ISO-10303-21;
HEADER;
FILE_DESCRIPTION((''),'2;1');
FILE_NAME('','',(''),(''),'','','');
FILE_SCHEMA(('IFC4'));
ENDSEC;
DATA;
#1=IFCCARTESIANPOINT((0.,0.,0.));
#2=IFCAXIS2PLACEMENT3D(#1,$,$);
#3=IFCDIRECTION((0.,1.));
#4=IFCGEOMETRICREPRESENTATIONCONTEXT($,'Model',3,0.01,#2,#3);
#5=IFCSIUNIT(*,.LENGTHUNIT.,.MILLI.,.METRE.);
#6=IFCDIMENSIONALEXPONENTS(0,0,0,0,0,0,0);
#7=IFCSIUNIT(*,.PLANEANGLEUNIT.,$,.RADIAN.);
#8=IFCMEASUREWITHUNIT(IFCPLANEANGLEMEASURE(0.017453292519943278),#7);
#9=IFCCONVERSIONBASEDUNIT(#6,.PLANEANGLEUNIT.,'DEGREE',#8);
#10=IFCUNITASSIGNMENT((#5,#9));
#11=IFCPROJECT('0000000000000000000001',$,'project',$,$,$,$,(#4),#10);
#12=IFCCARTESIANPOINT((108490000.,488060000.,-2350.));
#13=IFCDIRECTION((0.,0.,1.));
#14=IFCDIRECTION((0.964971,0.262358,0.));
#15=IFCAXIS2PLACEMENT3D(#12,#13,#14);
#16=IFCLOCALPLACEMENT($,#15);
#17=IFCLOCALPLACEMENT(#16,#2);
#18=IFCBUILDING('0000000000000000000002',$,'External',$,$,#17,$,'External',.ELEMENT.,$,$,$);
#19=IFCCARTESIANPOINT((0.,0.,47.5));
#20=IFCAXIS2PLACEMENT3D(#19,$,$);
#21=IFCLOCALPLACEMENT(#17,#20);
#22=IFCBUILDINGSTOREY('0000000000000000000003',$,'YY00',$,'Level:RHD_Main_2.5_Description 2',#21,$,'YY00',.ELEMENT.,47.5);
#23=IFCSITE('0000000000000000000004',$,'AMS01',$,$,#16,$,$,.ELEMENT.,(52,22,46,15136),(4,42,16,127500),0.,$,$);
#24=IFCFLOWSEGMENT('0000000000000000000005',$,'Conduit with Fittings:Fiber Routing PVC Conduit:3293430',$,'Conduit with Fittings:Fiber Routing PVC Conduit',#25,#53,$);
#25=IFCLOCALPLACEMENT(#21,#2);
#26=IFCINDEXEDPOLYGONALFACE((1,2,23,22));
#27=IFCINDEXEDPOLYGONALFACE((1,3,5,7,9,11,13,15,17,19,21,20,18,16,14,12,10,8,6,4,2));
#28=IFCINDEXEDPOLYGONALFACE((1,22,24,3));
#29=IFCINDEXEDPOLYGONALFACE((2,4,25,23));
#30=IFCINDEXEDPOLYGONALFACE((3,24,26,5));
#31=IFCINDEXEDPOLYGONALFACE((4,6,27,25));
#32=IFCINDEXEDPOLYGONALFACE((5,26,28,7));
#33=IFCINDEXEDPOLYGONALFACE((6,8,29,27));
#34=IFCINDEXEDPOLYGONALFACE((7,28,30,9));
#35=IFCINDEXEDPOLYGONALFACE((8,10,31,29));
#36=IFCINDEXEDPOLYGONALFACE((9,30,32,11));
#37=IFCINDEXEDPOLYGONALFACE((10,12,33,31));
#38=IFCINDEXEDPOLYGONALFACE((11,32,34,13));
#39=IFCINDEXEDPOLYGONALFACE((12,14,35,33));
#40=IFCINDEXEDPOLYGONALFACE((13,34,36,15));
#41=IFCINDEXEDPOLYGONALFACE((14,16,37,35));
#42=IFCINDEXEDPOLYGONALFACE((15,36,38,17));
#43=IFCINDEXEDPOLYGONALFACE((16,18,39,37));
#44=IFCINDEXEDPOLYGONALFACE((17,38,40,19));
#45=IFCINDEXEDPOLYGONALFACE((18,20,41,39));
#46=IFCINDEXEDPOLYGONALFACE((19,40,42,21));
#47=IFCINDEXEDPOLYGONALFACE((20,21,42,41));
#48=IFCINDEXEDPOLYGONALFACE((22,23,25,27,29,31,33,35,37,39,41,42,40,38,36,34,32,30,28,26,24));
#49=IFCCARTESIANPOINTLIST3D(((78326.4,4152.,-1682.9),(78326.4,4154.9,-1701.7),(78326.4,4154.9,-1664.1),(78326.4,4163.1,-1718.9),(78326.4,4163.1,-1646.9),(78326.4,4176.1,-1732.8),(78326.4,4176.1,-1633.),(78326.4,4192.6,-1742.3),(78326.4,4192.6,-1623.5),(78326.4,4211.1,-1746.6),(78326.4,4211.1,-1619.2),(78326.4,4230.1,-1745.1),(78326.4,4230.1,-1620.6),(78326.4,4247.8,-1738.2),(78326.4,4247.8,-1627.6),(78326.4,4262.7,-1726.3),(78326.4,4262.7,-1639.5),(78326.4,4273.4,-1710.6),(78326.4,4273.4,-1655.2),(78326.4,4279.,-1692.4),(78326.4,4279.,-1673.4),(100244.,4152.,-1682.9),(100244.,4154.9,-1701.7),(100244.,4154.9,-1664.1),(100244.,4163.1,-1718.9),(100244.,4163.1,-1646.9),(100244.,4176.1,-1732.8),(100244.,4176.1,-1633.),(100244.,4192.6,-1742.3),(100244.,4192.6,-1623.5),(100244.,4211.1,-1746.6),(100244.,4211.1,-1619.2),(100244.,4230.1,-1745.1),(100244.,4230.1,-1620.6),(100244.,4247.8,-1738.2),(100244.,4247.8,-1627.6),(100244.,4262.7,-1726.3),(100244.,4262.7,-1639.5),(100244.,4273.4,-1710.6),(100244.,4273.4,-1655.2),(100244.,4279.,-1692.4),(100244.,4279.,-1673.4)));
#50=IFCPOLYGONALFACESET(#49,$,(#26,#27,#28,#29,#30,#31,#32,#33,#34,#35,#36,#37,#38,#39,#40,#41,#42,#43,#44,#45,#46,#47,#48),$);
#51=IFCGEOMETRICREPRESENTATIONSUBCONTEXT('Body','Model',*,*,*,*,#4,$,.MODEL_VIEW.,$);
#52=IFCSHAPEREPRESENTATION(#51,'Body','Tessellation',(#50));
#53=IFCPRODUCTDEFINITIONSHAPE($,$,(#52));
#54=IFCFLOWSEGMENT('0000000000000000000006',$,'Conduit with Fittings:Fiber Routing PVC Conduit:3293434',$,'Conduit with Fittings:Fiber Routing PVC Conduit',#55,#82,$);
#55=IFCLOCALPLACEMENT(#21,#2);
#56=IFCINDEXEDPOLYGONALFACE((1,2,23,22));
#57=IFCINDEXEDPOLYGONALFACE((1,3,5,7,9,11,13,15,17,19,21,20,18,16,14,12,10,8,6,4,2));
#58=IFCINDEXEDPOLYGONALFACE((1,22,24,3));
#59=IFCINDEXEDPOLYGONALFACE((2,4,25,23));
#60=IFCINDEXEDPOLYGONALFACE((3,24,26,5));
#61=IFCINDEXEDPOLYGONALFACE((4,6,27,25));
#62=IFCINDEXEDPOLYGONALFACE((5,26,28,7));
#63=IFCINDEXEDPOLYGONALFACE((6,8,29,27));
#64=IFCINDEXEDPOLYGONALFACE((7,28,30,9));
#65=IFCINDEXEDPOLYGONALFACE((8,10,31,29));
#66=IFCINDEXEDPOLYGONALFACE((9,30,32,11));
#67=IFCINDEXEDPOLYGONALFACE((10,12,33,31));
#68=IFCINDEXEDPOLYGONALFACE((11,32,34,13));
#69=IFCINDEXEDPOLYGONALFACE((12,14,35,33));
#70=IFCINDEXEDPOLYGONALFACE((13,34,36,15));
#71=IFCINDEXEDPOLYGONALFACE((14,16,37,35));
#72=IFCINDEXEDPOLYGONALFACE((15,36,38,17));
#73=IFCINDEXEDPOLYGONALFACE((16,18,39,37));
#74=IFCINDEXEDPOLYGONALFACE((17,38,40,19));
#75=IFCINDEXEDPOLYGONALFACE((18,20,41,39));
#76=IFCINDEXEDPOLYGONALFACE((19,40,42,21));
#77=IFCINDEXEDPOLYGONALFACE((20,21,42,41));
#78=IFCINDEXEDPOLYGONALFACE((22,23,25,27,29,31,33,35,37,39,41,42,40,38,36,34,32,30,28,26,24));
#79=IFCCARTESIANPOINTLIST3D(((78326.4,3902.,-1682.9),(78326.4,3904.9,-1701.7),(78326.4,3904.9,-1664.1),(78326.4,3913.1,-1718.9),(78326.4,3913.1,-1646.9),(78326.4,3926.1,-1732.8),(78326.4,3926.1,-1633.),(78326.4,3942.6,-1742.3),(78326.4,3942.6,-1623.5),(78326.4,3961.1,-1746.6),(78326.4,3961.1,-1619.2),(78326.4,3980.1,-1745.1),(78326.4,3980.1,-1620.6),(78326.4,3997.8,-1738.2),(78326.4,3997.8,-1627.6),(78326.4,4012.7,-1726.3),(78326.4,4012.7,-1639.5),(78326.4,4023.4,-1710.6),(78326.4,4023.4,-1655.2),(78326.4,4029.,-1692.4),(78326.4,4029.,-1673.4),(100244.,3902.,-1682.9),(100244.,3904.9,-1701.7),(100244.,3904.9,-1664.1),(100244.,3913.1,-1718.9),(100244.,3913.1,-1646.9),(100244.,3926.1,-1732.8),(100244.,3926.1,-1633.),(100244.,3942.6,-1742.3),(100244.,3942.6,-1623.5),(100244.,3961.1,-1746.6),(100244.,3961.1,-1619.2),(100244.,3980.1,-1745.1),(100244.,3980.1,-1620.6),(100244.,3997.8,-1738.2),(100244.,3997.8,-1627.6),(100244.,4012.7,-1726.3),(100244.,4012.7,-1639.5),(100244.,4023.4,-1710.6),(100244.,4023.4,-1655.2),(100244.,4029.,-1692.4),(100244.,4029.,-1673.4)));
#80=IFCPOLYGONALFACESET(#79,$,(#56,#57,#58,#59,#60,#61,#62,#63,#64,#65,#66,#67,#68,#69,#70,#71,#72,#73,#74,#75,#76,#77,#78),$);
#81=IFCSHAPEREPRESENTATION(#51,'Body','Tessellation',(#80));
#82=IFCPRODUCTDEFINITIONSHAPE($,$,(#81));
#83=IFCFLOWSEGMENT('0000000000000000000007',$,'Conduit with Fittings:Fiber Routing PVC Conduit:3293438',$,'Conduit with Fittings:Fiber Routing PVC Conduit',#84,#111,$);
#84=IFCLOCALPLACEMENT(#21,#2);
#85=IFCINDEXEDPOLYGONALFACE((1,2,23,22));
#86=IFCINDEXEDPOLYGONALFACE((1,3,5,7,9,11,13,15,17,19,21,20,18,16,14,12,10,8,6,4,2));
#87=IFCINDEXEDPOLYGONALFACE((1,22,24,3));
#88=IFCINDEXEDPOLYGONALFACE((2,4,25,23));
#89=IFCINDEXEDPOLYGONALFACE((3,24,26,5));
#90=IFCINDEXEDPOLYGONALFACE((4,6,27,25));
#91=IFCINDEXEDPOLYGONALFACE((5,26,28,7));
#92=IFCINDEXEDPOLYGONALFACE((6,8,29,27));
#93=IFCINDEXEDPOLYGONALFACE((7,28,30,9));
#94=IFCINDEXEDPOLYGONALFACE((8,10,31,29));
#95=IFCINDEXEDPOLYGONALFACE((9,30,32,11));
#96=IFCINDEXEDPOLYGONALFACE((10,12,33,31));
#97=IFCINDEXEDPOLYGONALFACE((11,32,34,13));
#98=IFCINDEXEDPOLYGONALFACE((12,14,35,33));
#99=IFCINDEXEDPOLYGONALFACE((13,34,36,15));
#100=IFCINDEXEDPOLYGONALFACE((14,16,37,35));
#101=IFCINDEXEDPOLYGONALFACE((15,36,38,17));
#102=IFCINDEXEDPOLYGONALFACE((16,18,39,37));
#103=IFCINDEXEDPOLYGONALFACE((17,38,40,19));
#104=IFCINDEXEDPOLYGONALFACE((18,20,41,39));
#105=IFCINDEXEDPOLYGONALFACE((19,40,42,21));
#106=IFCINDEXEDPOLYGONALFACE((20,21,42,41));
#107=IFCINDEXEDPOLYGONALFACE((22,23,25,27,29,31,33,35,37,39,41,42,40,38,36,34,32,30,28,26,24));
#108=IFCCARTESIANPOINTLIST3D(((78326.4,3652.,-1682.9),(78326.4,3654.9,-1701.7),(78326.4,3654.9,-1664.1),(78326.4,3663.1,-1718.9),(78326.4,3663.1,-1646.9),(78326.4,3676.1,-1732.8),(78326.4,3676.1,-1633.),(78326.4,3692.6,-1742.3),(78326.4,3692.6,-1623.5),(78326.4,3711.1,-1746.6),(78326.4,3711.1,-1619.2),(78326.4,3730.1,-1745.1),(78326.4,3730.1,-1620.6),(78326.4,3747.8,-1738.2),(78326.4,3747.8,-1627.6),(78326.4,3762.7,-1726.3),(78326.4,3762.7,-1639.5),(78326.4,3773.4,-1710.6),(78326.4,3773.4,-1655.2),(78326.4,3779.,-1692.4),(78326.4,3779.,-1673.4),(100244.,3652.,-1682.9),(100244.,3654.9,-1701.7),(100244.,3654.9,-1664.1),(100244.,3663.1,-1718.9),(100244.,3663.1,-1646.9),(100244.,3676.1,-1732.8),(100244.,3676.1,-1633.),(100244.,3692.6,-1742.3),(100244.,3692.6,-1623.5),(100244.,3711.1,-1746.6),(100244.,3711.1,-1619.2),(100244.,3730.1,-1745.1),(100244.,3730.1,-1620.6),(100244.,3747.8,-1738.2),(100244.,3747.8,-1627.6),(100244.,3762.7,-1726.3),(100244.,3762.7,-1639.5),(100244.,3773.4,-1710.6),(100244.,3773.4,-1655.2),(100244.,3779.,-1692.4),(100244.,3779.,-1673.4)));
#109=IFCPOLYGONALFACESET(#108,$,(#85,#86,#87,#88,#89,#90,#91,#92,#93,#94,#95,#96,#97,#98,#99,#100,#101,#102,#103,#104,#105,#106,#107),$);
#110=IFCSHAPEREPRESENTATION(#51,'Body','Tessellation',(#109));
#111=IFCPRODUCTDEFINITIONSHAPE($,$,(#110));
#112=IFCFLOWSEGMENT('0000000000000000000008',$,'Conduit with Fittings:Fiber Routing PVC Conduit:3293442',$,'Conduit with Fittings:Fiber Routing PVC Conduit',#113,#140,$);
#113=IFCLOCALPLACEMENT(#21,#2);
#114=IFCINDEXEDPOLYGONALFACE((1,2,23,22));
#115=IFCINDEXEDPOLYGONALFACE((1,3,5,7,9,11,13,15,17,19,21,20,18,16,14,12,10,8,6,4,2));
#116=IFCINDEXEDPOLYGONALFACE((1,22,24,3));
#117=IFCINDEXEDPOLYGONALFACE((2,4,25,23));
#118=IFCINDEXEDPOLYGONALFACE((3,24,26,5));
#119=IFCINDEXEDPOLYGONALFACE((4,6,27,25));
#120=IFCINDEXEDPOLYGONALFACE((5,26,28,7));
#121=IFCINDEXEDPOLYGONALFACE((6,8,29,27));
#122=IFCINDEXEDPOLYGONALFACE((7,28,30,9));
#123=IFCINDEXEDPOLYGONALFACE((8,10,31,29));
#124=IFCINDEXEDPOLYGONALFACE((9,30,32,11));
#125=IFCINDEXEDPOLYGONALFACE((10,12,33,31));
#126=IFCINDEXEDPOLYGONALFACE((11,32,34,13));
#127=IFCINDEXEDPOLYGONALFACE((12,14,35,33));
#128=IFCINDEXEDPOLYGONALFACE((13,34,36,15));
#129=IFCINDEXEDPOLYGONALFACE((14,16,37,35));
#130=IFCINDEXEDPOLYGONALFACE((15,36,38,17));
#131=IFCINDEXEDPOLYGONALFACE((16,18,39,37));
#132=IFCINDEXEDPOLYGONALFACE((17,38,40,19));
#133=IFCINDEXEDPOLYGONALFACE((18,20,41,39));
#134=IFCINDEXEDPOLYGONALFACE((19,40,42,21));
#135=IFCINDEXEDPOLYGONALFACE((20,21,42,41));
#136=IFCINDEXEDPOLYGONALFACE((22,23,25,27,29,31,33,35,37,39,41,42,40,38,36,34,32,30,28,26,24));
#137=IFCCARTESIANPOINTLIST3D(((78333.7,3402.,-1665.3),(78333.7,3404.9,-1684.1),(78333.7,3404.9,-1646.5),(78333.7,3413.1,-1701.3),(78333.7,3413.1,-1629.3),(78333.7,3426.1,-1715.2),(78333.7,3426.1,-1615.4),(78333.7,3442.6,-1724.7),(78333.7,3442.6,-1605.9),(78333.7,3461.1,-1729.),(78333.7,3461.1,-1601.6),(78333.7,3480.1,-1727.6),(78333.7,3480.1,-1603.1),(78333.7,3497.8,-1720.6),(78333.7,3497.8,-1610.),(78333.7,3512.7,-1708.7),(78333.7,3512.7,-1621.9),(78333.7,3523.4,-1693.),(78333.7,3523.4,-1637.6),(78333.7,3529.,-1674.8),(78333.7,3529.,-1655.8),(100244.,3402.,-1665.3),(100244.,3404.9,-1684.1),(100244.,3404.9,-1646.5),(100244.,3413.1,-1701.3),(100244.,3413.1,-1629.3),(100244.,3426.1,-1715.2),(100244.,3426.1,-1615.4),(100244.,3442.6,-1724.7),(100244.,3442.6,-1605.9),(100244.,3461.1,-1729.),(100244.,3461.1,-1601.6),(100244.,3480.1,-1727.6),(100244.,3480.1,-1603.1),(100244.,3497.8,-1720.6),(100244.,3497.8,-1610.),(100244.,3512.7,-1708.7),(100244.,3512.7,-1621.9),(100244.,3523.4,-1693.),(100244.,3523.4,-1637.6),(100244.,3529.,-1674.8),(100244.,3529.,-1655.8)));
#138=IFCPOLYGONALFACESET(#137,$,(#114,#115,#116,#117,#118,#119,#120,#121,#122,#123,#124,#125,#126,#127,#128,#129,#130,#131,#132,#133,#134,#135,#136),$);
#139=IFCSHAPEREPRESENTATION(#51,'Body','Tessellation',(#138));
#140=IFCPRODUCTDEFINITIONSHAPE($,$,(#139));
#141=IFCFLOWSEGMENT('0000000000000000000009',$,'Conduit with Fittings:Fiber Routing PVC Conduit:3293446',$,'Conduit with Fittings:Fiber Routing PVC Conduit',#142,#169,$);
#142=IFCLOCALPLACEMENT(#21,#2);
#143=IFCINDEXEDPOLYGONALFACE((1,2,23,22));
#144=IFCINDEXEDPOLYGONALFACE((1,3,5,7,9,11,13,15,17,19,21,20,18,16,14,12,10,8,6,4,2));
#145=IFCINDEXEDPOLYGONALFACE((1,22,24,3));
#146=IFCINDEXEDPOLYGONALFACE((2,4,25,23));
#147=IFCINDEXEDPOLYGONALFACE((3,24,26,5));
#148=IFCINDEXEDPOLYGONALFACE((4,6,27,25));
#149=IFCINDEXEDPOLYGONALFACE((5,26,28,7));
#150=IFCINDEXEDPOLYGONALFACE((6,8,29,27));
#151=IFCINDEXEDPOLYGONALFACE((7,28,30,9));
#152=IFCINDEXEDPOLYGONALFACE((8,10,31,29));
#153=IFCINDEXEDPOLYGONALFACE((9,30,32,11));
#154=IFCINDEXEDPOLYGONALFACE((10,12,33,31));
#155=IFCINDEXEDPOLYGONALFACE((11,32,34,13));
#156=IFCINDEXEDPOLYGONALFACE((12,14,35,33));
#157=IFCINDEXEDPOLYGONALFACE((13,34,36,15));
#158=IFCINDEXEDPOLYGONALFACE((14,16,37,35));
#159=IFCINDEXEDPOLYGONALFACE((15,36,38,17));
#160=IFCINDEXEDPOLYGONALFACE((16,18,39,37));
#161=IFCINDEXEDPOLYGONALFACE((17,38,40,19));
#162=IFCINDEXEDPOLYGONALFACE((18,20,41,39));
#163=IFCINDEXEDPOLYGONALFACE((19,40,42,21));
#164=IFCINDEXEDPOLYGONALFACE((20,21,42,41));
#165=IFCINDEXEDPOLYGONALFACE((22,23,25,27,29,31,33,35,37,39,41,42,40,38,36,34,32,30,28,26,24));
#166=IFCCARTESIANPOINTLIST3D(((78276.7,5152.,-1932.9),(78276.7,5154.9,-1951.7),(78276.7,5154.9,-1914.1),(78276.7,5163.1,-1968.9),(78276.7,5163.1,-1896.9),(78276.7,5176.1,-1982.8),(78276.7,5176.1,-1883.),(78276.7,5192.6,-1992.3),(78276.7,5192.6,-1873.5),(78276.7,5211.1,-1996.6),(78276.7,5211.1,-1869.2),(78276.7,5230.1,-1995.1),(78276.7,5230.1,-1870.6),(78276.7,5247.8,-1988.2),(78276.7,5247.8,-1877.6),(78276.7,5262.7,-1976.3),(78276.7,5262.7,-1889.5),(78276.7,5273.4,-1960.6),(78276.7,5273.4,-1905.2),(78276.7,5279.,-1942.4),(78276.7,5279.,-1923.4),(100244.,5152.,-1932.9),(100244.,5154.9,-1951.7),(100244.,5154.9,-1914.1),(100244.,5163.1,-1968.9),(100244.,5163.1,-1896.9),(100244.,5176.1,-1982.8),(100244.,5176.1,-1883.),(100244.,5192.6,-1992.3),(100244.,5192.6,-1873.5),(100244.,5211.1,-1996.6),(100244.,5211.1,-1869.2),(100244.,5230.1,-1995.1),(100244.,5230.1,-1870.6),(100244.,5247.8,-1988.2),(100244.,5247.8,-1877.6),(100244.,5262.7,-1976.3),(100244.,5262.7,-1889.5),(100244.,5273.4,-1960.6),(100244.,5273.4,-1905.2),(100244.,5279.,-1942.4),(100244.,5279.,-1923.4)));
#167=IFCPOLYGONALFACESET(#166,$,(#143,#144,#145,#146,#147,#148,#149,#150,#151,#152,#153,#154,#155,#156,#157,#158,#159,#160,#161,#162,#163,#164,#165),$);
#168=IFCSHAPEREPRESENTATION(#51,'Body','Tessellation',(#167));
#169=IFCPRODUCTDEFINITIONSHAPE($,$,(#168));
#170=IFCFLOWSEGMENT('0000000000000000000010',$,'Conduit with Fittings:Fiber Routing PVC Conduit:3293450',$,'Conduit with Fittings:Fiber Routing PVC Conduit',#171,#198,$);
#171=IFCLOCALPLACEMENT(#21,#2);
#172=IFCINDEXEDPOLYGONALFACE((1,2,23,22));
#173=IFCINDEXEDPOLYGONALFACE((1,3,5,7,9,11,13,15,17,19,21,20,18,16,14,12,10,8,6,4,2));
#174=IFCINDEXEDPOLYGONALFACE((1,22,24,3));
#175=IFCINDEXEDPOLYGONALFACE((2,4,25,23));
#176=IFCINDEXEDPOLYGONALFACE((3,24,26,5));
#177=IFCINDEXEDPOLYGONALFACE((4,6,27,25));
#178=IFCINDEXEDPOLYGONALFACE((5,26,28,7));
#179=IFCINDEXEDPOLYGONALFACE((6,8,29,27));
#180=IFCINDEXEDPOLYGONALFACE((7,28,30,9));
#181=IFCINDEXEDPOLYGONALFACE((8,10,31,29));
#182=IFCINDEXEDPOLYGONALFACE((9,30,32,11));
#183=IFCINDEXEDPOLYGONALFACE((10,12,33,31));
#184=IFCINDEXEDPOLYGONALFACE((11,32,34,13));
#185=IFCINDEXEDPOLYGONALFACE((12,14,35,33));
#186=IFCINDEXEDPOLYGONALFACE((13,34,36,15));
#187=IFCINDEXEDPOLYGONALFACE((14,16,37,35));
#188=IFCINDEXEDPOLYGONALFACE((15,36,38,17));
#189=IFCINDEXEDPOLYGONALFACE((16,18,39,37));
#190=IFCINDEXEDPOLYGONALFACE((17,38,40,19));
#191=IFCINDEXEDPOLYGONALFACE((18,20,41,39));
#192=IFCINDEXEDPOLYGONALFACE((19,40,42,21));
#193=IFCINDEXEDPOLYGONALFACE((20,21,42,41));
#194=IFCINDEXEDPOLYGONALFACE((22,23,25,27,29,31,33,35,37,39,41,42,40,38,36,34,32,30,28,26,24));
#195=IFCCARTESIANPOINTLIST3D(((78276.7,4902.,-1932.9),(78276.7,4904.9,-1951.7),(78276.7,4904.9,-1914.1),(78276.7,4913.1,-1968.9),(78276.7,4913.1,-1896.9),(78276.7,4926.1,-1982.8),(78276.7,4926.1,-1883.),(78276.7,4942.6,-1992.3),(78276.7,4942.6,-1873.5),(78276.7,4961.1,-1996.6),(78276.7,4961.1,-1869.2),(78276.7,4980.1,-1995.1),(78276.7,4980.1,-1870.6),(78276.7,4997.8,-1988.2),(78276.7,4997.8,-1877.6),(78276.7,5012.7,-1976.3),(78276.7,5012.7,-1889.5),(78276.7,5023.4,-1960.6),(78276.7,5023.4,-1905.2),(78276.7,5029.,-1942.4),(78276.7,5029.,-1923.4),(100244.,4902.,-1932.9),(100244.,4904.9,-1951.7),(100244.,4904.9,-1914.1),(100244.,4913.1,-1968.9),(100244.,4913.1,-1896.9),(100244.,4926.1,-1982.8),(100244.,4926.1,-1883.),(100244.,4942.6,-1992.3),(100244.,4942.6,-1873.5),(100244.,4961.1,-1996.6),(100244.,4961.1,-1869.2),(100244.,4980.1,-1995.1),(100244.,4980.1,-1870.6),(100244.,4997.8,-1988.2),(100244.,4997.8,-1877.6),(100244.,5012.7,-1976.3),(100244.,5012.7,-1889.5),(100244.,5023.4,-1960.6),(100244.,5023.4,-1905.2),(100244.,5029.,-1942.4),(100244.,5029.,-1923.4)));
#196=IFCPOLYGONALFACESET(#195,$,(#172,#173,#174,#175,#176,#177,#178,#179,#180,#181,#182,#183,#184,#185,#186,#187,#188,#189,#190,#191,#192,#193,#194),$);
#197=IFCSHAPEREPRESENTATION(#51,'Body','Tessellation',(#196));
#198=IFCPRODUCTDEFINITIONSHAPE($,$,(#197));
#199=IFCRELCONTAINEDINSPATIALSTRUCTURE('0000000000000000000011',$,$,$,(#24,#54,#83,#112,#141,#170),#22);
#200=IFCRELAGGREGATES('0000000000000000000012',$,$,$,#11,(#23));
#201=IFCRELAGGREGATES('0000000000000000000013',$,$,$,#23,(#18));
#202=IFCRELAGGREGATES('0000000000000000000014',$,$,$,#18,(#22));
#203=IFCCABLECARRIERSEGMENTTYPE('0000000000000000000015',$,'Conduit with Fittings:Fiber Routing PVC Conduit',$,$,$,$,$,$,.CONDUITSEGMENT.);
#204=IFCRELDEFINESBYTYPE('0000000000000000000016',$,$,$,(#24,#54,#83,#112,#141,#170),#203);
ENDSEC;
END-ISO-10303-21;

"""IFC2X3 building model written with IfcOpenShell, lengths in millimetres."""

from ifc_helpers import new_model, entity, si_unit, converted_unit, direction, frame, frame_2d, origin, origin_2d_with_axis, place, context, subcontext, project, spatial, circle, extrude, type_object, element, save


model = new_model("IFC2X3")

# Units and contexts
model_context = context("Model", 3, precision=0.01, world=origin(), true_north=direction((0.0, 1.0)))
body_context = subcontext(model_context, "Body", "Model", "MODEL_VIEW")
ifc_project = project(units=[si_unit("LENGTHUNIT", "METRE", prefix="MILLI"), converted_unit("PLANEANGLEUNIT", "DEGREE", entity("IfcPlaneAngleMeasure", 0.017453292519943278), si_unit("PLANEANGLEUNIT", "RADIAN"), dimensions=[0, 0, 0, 0, 0, 0, 0])], contexts=[model_context])

# Site, building, storey
site_placement = place(None, frame((108490000.0, 488060000.0, -2350.0), z_axis=(0.0, 0.0, 1.0), x_axis=(0.964971, 0.262358, 0.0)))
site = spatial("IfcSite", under=ifc_project, at=site_placement, Name="AMS01", CompositionType="ELEMENT", RefLatitude=(52, 22, 46, 15136), RefLongitude=(4, 42, 16, 127500), RefElevation=0.0)
building_placement = place(site_placement, origin())
building = spatial("IfcBuilding", under=site, at=building_placement, Name="External", LongName="External", CompositionType="ELEMENT")
storey_placement = place(building_placement, frame((0.0, 0.0, 47.5)))
storey = spatial("IfcBuildingStorey", under=building, at=storey_placement, Name="YY00", ObjectType="Level:RHD_Main_2.5_Description 2", LongName="YY00", CompositionType="ELEMENT", Elevation=47.5)

# Flow segments
cable_carrier_segment_type = type_object("IfcCableCarrierSegmentType", Name="Conduit with Fittings:Fiber Routing PVC Conduit", PredefinedType="CONDUITSEGMENT")
flow_segment_1_placement = place(storey_placement, origin())
element("IfcFlowSegment", 1, at=flow_segment_1_placement, inside=storey, type_object=cable_carrier_segment_type, Name="Conduit with Fittings:Fiber Routing PVC Conduit:3293430", ObjectType="Conduit with Fittings:Fiber Routing PVC Conduit", context=body_context, shape_type="SweptSolid", body=[
    extrude(circle(Radius=63.9, at=frame_2d((0.0, 0.0), x_axis=(1.0, 0.0))), frame((78326.4, 4215.9, -1682.9), z_axis=(1.0, 0.0, 0.0), x_axis=(0.0, -1.0, 0.0)), (0.0, 0.0, 1.0), 21917.6),
])
flow_segment_2_placement = place(storey_placement, origin())
element("IfcFlowSegment", 2, at=flow_segment_2_placement, inside=storey, type_object=cable_carrier_segment_type, Name="Conduit with Fittings:Fiber Routing PVC Conduit:3293434", ObjectType="Conduit with Fittings:Fiber Routing PVC Conduit", context=body_context, shape_type="SweptSolid", body=[
    extrude(circle(Radius=63.9, at=origin_2d_with_axis()), frame((78326.4, 3965.9, -1682.9), z_axis=(1.0, 0.0, 0.0), x_axis=(0.0, -1.0, 0.0)), (0.0, 0.0, 1.0), 21917.6),
])
flow_segment_3_placement = place(storey_placement, origin())
element("IfcFlowSegment", 3, at=flow_segment_3_placement, inside=storey, type_object=cable_carrier_segment_type, Name="Conduit with Fittings:Fiber Routing PVC Conduit:3293438", ObjectType="Conduit with Fittings:Fiber Routing PVC Conduit", context=body_context, shape_type="SweptSolid", body=[
    extrude(circle(Radius=63.9, at=frame_2d((0.0, 0.0), x_axis=(1.0, 0.0))), frame((78326.4, 3715.9, -1682.9), z_axis=(1.0, 0.0, 0.0), x_axis=(0.0, -1.0, 0.0)), (0.0, 0.0, 1.0), 21917.6),
])
flow_segment_4_placement = place(storey_placement, origin())
element("IfcFlowSegment", 4, at=flow_segment_4_placement, inside=storey, type_object=cable_carrier_segment_type, Name="Conduit with Fittings:Fiber Routing PVC Conduit:3293442", ObjectType="Conduit with Fittings:Fiber Routing PVC Conduit", context=body_context, shape_type="SweptSolid", body=[
    extrude(circle(Radius=63.9, at=frame_2d((0.0, 0.0), x_axis=(1.0, 0.0))), frame((78333.7, 3465.9, -1665.3), z_axis=(1.0, 0.0, 0.0), x_axis=(0.0, -1.0, 0.0)), (0.0, 0.0, 1.0), 21910.3),
])
flow_segment_5_placement = place(storey_placement, origin())
element("IfcFlowSegment", 5, at=flow_segment_5_placement, inside=storey, type_object=cable_carrier_segment_type, Name="Conduit with Fittings:Fiber Routing PVC Conduit:3293446", ObjectType="Conduit with Fittings:Fiber Routing PVC Conduit", context=body_context, shape_type="SweptSolid", body=[
    extrude(circle(Radius=63.9, at=origin_2d_with_axis()), frame((78276.7, 5215.9, -1932.9), z_axis=(1.0, 0.0, 0.0), x_axis=(0.0, -1.0, 0.0)), (0.0, 0.0, 1.0), 21967.3),
])
flow_segment_6_placement = place(storey_placement, origin())
element("IfcFlowSegment", 6, at=flow_segment_6_placement, inside=storey, type_object=cable_carrier_segment_type, Name="Conduit with Fittings:Fiber Routing PVC Conduit:3293450", ObjectType="Conduit with Fittings:Fiber Routing PVC Conduit", context=body_context, shape_type="SweptSolid", body=[
    extrude(circle(Radius=63.9, at=frame_2d((0.0, 0.0), x_axis=(1.0, 0.0))), frame((78276.7, 4965.9, -1932.9), z_axis=(1.0, 0.0, 0.0), x_axis=(0.0, -1.0, 0.0)), (0.0, 0.0, 1.0), 21967.3),
])

save(model, "model.ifc")
